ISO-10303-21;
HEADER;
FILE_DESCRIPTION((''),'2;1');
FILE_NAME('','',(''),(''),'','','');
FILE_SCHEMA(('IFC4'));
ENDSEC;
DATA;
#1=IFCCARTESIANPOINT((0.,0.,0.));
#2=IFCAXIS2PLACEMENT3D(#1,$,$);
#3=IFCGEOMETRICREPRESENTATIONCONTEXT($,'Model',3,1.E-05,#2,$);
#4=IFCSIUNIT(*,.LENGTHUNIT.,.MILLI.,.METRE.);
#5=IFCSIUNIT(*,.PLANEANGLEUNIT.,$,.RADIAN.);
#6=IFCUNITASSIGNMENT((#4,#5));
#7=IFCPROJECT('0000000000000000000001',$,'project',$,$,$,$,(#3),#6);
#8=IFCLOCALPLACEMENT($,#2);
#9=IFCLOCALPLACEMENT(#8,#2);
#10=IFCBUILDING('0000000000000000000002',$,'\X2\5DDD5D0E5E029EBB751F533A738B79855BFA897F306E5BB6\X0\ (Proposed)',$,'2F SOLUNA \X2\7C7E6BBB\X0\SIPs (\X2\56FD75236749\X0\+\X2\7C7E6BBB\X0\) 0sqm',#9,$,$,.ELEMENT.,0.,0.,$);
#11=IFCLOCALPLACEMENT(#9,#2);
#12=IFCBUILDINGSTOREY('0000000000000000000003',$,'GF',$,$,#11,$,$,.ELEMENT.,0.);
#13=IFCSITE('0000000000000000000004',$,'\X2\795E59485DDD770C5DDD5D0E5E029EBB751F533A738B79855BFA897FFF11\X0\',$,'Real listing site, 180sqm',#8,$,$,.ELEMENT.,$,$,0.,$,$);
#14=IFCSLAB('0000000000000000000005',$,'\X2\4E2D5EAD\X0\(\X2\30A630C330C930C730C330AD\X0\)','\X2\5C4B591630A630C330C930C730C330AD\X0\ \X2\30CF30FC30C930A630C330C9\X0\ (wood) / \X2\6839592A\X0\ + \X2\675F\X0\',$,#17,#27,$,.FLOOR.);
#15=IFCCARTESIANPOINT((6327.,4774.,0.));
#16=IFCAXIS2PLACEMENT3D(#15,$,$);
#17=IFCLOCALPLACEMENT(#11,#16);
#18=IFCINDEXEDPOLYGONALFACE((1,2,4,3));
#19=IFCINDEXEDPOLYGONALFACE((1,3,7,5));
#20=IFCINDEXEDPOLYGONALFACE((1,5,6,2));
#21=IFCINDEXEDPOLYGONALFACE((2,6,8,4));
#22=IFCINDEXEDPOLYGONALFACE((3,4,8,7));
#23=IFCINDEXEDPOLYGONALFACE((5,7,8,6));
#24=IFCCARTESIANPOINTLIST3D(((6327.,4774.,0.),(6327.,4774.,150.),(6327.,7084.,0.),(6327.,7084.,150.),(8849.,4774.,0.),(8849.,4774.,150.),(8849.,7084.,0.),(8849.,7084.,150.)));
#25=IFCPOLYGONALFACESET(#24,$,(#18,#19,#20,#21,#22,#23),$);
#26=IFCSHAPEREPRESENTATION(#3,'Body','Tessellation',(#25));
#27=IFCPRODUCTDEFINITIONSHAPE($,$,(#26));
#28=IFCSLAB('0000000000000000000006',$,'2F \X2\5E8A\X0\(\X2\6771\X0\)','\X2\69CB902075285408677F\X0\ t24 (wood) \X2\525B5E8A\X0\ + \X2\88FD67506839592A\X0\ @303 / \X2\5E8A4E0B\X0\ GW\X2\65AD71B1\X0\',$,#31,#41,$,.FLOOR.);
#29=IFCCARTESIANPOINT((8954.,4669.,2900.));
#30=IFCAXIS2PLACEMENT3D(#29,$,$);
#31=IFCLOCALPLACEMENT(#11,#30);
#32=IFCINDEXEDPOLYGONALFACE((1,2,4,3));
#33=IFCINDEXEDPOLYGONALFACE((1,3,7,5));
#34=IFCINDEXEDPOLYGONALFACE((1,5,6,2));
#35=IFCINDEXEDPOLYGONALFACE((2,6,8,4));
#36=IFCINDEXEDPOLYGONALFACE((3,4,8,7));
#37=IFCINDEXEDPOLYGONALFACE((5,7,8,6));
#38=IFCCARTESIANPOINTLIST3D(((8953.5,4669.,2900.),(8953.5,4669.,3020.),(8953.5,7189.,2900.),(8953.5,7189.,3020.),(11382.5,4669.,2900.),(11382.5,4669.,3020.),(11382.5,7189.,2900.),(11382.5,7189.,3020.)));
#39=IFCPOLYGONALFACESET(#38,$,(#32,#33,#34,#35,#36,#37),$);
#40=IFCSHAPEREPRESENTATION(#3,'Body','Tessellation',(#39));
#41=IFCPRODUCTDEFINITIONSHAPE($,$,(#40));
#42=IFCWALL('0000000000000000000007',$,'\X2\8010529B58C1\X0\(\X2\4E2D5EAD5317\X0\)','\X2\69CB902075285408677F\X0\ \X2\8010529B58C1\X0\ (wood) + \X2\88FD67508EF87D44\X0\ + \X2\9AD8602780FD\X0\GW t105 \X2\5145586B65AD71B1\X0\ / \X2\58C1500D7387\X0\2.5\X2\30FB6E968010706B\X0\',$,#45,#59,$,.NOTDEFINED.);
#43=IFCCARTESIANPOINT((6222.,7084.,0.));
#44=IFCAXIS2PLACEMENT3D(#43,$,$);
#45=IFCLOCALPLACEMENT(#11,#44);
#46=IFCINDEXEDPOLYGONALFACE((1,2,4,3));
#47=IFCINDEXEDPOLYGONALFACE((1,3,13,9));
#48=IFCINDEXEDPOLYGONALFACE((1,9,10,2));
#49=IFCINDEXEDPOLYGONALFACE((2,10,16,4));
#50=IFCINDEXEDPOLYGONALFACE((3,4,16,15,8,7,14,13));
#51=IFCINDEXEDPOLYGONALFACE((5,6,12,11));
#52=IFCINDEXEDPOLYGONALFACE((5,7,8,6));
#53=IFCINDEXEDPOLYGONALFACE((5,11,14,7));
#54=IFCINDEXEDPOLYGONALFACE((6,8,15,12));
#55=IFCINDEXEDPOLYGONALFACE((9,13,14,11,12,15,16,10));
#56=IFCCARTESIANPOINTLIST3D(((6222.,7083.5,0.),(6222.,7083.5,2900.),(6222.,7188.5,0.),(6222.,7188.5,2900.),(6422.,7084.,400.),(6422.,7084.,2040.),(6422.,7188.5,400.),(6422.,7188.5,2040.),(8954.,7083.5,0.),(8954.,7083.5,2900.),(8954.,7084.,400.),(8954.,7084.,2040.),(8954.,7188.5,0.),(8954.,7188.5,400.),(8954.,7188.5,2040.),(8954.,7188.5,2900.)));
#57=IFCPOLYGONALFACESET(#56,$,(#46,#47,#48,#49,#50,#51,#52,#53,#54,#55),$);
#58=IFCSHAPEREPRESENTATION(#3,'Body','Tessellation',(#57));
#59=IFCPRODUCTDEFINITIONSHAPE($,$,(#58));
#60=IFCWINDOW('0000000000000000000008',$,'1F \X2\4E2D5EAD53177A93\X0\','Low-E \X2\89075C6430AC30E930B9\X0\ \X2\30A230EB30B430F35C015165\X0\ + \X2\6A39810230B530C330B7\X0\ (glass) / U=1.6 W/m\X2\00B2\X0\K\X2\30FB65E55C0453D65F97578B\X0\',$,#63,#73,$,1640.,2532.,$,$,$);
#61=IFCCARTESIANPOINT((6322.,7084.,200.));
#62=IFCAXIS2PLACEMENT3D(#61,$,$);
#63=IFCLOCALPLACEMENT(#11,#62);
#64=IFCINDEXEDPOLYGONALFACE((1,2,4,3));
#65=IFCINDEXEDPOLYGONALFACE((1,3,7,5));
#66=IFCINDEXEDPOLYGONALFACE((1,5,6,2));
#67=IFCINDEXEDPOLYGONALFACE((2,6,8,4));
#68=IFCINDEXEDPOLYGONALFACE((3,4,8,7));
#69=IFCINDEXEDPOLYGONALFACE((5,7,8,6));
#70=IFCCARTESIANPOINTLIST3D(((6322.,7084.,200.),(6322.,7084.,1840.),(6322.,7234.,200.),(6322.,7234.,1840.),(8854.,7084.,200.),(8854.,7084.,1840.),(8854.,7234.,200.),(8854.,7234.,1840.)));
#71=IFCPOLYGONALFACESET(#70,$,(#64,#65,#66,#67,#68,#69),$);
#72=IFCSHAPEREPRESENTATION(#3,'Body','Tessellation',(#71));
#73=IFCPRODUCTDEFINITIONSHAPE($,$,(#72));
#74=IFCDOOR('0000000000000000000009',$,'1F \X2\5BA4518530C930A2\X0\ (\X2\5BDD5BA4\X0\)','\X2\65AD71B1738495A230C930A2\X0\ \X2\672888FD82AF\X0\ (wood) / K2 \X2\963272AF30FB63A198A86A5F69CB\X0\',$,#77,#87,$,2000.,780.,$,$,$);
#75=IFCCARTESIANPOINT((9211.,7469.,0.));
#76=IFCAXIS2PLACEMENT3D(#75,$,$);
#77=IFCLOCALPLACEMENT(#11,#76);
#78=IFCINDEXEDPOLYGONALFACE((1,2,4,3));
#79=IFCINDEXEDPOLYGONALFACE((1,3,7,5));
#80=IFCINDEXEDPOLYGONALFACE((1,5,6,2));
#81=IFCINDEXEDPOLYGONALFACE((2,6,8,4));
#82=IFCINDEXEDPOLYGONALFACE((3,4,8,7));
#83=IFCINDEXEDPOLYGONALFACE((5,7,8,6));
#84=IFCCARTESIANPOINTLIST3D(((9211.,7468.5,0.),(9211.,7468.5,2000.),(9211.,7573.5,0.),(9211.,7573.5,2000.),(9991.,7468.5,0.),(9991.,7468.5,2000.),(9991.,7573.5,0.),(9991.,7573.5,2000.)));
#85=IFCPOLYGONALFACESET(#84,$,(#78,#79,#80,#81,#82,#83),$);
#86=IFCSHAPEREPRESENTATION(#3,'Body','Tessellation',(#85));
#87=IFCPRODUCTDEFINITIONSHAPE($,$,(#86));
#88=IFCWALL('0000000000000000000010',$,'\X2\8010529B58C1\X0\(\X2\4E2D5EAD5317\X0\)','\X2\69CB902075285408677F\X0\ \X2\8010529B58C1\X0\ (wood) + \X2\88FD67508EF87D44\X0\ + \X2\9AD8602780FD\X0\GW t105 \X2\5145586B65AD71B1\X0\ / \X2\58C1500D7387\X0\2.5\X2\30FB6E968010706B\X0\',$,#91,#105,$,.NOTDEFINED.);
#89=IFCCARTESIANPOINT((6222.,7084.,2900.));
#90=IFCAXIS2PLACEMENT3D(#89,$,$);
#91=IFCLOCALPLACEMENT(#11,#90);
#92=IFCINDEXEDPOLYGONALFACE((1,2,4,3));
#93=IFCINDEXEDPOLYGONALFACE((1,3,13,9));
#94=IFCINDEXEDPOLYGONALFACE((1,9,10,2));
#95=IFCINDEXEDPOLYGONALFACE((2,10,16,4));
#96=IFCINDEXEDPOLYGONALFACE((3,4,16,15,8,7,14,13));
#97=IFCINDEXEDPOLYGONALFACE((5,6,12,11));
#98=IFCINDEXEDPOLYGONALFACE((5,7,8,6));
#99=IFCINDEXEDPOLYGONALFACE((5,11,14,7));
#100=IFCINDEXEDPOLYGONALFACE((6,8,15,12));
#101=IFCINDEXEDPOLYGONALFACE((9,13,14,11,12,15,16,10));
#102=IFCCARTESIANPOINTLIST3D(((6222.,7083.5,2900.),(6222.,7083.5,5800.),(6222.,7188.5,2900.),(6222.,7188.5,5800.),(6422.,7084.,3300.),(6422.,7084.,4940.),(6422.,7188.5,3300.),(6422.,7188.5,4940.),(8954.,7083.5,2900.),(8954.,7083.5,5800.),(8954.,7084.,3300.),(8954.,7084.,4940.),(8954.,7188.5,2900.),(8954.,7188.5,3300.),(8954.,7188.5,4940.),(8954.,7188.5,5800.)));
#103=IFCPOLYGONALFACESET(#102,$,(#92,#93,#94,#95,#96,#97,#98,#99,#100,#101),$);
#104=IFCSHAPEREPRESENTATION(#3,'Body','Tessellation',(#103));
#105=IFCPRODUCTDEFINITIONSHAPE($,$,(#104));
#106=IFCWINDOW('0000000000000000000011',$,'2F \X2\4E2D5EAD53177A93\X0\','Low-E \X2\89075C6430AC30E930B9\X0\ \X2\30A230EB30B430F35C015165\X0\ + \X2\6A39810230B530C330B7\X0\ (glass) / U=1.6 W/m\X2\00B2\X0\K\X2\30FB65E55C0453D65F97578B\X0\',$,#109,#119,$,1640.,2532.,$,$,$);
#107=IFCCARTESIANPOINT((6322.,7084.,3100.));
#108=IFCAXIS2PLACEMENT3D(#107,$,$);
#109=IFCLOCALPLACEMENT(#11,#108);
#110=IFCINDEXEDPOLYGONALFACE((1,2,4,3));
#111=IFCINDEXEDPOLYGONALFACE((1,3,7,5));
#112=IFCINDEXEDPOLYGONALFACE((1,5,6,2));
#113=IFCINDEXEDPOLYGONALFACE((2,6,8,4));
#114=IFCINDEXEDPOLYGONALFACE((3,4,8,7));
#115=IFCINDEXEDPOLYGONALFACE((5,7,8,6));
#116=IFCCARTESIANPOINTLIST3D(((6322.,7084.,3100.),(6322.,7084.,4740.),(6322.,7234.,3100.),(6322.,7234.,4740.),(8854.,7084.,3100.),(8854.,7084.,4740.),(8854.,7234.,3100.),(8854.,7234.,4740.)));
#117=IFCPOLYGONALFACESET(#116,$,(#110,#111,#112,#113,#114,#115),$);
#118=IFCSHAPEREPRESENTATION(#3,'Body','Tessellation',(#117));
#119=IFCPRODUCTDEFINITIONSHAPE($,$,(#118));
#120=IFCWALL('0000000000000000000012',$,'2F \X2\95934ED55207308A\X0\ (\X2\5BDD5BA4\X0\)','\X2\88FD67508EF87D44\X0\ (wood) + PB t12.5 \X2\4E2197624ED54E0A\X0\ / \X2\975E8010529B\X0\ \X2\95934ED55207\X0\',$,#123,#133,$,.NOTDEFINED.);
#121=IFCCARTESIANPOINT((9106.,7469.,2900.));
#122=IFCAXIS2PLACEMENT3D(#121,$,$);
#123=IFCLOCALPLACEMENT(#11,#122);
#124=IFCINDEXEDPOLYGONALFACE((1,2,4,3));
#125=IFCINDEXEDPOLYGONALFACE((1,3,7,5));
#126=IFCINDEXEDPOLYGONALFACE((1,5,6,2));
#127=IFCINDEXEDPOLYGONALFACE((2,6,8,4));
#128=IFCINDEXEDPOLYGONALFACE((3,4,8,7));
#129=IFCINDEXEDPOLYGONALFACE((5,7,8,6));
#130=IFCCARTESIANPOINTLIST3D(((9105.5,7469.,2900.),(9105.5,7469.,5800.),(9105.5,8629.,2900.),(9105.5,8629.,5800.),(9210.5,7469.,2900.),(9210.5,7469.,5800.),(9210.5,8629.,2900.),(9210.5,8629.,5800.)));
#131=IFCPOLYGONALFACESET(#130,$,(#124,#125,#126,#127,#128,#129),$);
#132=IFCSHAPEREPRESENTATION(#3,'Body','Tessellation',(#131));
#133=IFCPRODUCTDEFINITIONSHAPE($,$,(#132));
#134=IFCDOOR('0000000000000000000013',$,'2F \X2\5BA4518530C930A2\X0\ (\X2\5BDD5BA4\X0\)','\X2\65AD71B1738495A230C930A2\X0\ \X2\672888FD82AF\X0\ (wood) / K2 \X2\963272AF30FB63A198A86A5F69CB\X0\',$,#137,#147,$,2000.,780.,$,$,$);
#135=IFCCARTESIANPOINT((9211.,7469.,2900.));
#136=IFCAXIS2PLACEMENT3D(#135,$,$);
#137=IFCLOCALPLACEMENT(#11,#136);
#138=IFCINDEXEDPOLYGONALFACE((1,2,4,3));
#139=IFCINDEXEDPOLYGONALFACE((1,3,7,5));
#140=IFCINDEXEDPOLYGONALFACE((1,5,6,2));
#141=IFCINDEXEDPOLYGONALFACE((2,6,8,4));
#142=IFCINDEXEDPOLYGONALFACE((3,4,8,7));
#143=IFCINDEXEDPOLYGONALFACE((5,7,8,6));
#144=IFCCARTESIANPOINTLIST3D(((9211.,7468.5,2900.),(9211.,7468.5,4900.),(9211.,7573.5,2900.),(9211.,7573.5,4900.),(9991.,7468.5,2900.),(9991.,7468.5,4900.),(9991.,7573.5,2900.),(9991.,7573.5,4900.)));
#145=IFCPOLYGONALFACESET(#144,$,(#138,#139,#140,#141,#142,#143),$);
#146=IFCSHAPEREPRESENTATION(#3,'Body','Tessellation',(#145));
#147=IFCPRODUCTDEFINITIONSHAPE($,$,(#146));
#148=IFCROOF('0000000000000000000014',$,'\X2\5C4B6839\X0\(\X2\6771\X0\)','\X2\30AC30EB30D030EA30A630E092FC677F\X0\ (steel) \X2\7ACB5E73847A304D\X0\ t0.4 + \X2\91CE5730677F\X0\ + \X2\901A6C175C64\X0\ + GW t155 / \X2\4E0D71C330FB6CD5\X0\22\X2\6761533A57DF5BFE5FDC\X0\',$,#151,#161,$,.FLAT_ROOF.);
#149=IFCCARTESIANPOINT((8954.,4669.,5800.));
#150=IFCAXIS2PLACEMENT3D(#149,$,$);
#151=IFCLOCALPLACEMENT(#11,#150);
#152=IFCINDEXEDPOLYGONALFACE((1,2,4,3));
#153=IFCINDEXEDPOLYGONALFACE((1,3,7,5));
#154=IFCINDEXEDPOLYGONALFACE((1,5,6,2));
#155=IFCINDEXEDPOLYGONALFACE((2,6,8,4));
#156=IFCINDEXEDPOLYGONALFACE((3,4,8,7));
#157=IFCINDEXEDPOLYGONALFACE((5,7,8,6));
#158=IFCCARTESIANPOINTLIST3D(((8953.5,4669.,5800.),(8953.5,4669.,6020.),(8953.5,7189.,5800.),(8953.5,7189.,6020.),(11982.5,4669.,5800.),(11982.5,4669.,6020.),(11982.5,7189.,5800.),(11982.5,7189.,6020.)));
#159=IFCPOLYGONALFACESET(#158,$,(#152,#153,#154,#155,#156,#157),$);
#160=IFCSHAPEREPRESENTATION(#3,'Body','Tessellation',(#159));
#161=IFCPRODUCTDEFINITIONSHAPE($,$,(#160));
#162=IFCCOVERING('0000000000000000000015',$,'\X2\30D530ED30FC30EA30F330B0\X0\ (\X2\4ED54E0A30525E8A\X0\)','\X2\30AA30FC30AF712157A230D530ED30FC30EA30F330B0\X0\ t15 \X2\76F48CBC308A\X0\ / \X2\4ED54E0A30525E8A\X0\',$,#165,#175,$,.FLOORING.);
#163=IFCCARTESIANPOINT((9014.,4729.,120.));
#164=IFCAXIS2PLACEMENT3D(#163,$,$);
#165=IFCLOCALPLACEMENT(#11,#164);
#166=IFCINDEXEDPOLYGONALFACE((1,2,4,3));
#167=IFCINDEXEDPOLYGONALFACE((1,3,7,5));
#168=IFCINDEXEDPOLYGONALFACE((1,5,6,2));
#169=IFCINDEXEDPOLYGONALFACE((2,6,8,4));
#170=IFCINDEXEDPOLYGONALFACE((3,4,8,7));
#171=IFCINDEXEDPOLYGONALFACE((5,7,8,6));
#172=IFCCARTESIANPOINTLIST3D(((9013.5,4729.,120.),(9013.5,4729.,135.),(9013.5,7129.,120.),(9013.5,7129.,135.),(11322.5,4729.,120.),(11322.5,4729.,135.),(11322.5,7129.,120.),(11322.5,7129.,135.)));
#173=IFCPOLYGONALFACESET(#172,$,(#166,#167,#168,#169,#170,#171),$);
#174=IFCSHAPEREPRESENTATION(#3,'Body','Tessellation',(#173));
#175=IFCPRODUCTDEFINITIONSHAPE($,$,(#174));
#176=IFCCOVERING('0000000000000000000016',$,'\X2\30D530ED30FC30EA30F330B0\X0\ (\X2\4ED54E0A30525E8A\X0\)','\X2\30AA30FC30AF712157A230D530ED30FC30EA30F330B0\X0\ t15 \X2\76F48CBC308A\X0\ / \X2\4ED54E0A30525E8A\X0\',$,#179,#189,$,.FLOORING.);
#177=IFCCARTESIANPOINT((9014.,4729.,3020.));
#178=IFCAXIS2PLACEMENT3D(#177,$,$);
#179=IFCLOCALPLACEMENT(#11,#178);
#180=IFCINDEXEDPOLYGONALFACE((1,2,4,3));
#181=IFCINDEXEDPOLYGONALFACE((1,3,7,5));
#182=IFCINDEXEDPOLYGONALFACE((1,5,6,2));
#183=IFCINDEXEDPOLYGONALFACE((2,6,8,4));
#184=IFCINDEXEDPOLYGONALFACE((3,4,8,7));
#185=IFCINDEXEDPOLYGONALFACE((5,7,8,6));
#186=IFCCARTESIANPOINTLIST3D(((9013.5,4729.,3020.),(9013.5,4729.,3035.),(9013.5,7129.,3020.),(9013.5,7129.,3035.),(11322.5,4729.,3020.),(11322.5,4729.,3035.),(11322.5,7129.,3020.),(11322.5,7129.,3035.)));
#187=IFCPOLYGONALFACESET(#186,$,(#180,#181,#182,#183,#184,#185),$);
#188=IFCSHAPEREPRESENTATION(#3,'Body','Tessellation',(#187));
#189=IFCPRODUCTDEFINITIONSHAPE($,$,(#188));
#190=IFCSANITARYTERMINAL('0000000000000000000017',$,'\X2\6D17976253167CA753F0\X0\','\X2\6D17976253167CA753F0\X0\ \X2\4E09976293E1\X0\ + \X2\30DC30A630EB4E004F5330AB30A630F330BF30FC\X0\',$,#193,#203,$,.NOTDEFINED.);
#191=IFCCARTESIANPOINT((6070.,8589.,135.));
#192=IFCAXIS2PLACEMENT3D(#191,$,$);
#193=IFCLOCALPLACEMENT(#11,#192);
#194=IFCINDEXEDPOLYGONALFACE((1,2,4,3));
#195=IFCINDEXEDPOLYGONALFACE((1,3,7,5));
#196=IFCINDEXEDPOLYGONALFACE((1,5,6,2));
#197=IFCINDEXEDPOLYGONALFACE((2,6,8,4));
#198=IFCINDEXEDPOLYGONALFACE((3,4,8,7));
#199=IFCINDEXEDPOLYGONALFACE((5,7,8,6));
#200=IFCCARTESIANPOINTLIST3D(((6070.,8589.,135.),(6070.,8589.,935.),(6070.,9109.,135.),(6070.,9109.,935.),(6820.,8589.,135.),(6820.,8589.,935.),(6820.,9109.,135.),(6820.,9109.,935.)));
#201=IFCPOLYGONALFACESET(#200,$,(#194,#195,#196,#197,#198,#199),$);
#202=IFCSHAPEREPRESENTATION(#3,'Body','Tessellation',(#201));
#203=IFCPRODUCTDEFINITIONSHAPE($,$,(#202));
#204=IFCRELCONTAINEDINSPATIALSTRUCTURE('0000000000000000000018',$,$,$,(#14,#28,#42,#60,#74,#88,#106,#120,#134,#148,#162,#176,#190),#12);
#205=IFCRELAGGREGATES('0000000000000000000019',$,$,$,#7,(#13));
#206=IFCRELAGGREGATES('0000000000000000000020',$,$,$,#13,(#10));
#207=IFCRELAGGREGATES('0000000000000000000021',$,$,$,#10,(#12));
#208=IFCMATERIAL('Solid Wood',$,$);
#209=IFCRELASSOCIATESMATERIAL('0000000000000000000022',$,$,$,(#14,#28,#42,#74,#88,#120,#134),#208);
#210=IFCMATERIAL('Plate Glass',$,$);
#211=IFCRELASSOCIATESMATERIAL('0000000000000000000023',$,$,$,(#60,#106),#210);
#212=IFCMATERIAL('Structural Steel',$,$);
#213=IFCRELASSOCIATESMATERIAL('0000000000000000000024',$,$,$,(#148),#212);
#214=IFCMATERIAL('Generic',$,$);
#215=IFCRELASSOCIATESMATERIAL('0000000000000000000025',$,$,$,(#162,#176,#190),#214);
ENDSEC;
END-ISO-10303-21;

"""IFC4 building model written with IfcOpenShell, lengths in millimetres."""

from ifc_helpers import new_model, si_unit, frame, frame_2d, origin, place, context, project, spatial, rectangle, extrude, material, element, fill, save


model = new_model("IFC4")

# Units and contexts
model_context = context("Model", 3, precision=1e-05, world=origin())
ifc_project = project(units=[si_unit("LENGTHUNIT", "METRE", prefix="MILLI"), si_unit("PLANEANGLEUNIT", "RADIAN")], contexts=[model_context])

# Site, building, storey
site_placement = place(None, origin())
site = spatial("IfcSite", under=ifc_project, at=site_placement, Name="神奈川県川崎市麻生区王禅寺西１", ObjectType="Real listing site, 180sqm", CompositionType="ELEMENT", RefElevation=0.0)
building_placement = place(site_placement, origin())
building = spatial("IfcBuilding", under=site, at=building_placement, Name="川崎市麻生区王禅寺西の家 (Proposed)", ObjectType="2F SOLUNA 籾殻SIPs (国産杉+籾殻) 0sqm", CompositionType="ELEMENT", ElevationOfRefHeight=0.0, ElevationOfTerrain=0.0)
storey_placement = place(building_placement, origin())
storey = spatial("IfcBuildingStorey", under=building, at=storey_placement, Name="GF", CompositionType="ELEMENT", Elevation=0.0)

# Slabs
ifc_material_1 = material(Name="Solid Wood")
slab_1_placement = place(storey_placement, frame((6327.0, 4774.0, 0.0)))
element("IfcSlab", 1, at=slab_1_placement, inside=storey, material=ifc_material_1, Name="中庭(ウッドデッキ)", Description="屋外ウッドデッキ ハードウッド (wood) / 根太 + 束", PredefinedType="FLOOR", context=model_context, shape_type="SweptSolid", body=[
    extrude(rectangle(XDim=2522.0, YDim=2310.0, at=frame_2d((1261.0, 1155.0))), frame((6327.0, 4774.0, 0.0)), (0.0, 0.0, 1.0), 150.0),
])
slab_2_placement = place(storey_placement, frame((8954.0, 4669.0, 2900.0)))
element("IfcSlab", 2, at=slab_2_placement, inside=storey, material=ifc_material_1, Name="2F 床(東)", Description="構造用合板 t24 (wood) 剛床 + 製材根太 @303 / 床下 GW断熱", PredefinedType="FLOOR", context=model_context, shape_type="SweptSolid", body=[
    extrude(rectangle(XDim=2429.0, YDim=2520.0, at=frame_2d((1214.0, 1260.0))), frame((8954.0, 4669.0, 2900.0)), (0.0, 0.0, 1.0), 120.0),
])

# Wall, opening, window
wall_1_placement = place(storey_placement, frame((6222.0, 7084.0, 0.0)))
wall_1 = element("IfcWall", 3, at=wall_1_placement, inside=storey, material=ifc_material_1, Name="耐力壁(中庭北)", Description="構造用合板 耐力壁 (wood) + 製材軸組 + 高性能GW t105 充填断熱 / 壁倍率2.5・準耐火", PredefinedType="NOTDEFINED", context=model_context, shape_type="SweptSolid", body=[
    extrude(rectangle(XDim=2732.0, YDim=105.0, at=frame_2d((1366.0, 52.0))), frame((6222.0, 7084.0, 0.0)), (0.0, 0.0, 1.0), 2900.0),
])
opening_1_placement = place(storey_placement, frame((6322.0, 7084.0, 200.0)))
opening_1 = element("IfcOpeningElement", 4, at=opening_1_placement, cuts=wall_1, PredefinedType="NOTDEFINED", context=model_context, shape_type="SweptSolid", body=[
    extrude(rectangle(XDim=2532.0, YDim=150.0, at=frame_2d((1266.0, 75.0))), frame((6322.0, 7084.0, 200.0)), (0.0, 0.0, 1.0), 1640.0),
])
ifc_material_2 = material(Name="Plate Glass")
window_1_placement = place(storey_placement, frame((6322.0, 7084.0, 200.0)))
window_1 = element("IfcWindow", 5, at=window_1_placement, inside=storey, material=ifc_material_2, Name="1F 中庭北窓", Description="Low-E 複層ガラス アルゴン封入 + 樹脂サッシ (glass) / U=1.6 W/m²K・日射取得型", OverallHeight=1640.0, OverallWidth=2532.0, context=model_context, shape_type="SweptSolid", body=[
    extrude(rectangle(XDim=2532.0, YDim=150.0, at=frame_2d((1266.0, 75.0))), frame((6322.0, 7084.0, 200.0)), (0.0, 0.0, 1.0), 1640.0),
])
fill(opening_1, window_1)

# Door
door_1_placement = place(storey_placement, frame((9211.0, 7469.0, 0.0)))
element("IfcDoor", 6, at=door_1_placement, inside=storey, material=ifc_material_1, Name="1F 室内ドア (寝室)", Description="断熱玄関ドア 木製芯 (wood) / K2 防犯・採風機構", OverallHeight=2000.0, OverallWidth=780.0, context=model_context, shape_type="SweptSolid", body=[
    extrude(rectangle(XDim=780.0, YDim=105.0, at=frame_2d((390.0, 52.0))), frame((9211.0, 7469.0, 0.0)), (0.0, 0.0, 1.0), 2000.0),
])

# Wall, opening, window
wall_2_placement = place(storey_placement, frame((6222.0, 7084.0, 2900.0)))
wall_2 = element("IfcWall", 7, at=wall_2_placement, inside=storey, material=ifc_material_1, Name="耐力壁(中庭北)", Description="構造用合板 耐力壁 (wood) + 製材軸組 + 高性能GW t105 充填断熱 / 壁倍率2.5・準耐火", PredefinedType="NOTDEFINED", context=model_context, shape_type="SweptSolid", body=[
    extrude(rectangle(XDim=2732.0, YDim=105.0, at=frame_2d((1366.0, 52.0))), frame((6222.0, 7084.0, 2900.0)), (0.0, 0.0, 1.0), 2900.0),
])
opening_2_placement = place(storey_placement, frame((6322.0, 7084.0, 3100.0)))
opening_2 = element("IfcOpeningElement", 8, at=opening_2_placement, cuts=wall_2, PredefinedType="NOTDEFINED", context=model_context, shape_type="SweptSolid", body=[
    extrude(rectangle(XDim=2532.0, YDim=150.0, at=frame_2d((1266.0, 75.0))), frame((6322.0, 7084.0, 3100.0)), (0.0, 0.0, 1.0), 1640.0),
])
window_2_placement = place(storey_placement, frame((6322.0, 7084.0, 3100.0)))
window_2 = element("IfcWindow", 9, at=window_2_placement, inside=storey, material=ifc_material_2, Name="2F 中庭北窓", Description="Low-E 複層ガラス アルゴン封入 + 樹脂サッシ (glass) / U=1.6 W/m²K・日射取得型", OverallHeight=1640.0, OverallWidth=2532.0, context=model_context, shape_type="SweptSolid", body=[
    extrude(rectangle(XDim=2532.0, YDim=150.0, at=frame_2d((1266.0, 75.0))), frame((6322.0, 7084.0, 3100.0)), (0.0, 0.0, 1.0), 1640.0),
])
fill(opening_2, window_2)

# Wall
wall_3_placement = place(storey_placement, frame((9106.0, 7469.0, 2900.0)))
element("IfcWall", 10, at=wall_3_placement, inside=storey, material=ifc_material_1, Name="2F 間仕切り (寝室)", Description="製材軸組 (wood) + PB t12.5 両面仕上 / 非耐力 間仕切", PredefinedType="NOTDEFINED", context=model_context, shape_type="SweptSolid", body=[
    extrude(rectangle(XDim=105.0, YDim=1160.0, at=frame_2d((52.0, 580.0))), frame((9106.0, 7469.0, 2900.0)), (0.0, 0.0, 1.0), 2900.0),
])

# Door
door_2_placement = place(storey_placement, frame((9211.0, 7469.0, 2900.0)))
element("IfcDoor", 11, at=door_2_placement, inside=storey, material=ifc_material_1, Name="2F 室内ドア (寝室)", Description="断熱玄関ドア 木製芯 (wood) / K2 防犯・採風機構", OverallHeight=2000.0, OverallWidth=780.0, context=model_context, shape_type="SweptSolid", body=[
    extrude(rectangle(XDim=780.0, YDim=105.0, at=frame_2d((390.0, 52.0))), frame((9211.0, 7469.0, 2900.0)), (0.0, 0.0, 1.0), 2000.0),
])

# Roof
ifc_material_3 = material(Name="Structural Steel")
for number, where, name in (
    (12, (8954.0, 4669.0, 5800.0), "屋根(東)"),
):
    element("IfcRoof", number, at=place(storey_placement, frame(where)), inside=storey, material=ifc_material_3, Name=name, Description="ガルバリウム鋼板 (steel) 立平葺き t0.4 + 野地板 + 通気層 + GW t155 / 不燃・法22条区域対応", PredefinedType="FLAT_ROOF", context=model_context, shape_type="SweptSolid", body=[
        extrude(rectangle(XDim=3029.0, YDim=2520.0, at=frame_2d((1514.0, 1260.0))), frame((8954.0, 4669.0, 5800.0)), (0.0, 0.0, 1.0), 220.0),
    ])

# Coverings
ifc_material_4 = material(Name="Generic")
covering_1_placement = place(storey_placement, frame((9014.0, 4729.0, 120.0)))
element("IfcCovering", 13, at=covering_1_placement, inside=storey, material=ifc_material_4, Name="フローリング (仕上げ床)", Description="オーク無垢フローリング t15 直貼り / 仕上げ床", PredefinedType="FLOORING", context=model_context, shape_type="SweptSolid", body=[
    extrude(rectangle(XDim=2309.0, YDim=2400.0, at=frame_2d((1154.0, 1200.0))), frame((9014.0, 4729.0, 120.0)), (0.0, 0.0, 1.0), 15.0),
])
covering_2_placement = place(storey_placement, frame((9014.0, 4729.0, 3020.0)))
element("IfcCovering", 14, at=covering_2_placement, inside=storey, material=ifc_material_4, Name="フローリング (仕上げ床)", Description="オーク無垢フローリング t15 直貼り / 仕上げ床", PredefinedType="FLOORING", context=model_context, shape_type="SweptSolid", body=[
    extrude(rectangle(XDim=2309.0, YDim=2400.0, at=frame_2d((1154.0, 1200.0))), frame((9014.0, 4729.0, 3020.0)), (0.0, 0.0, 1.0), 15.0),
])

# Sanitary terminal
sanitary_terminal_1_placement = place(storey_placement, frame((6070.0, 8589.0, 135.0)))
element("IfcSanitaryTerminal", 15, at=sanitary_terminal_1_placement, inside=storey, material=ifc_material_4, Name="洗面化粧台", Description="洗面化粧台 三面鏡 + ボウル一体カウンター", PredefinedType="NOTDEFINED", context=model_context, shape_type="SweptSolid", body=[
    extrude(rectangle(XDim=750.0, YDim=520.0, at=frame_2d((375.0, 260.0))), frame((6070.0, 8589.0, 135.0)), (0.0, 0.0, 1.0), 800.0),
])

save(model, "model.ifc")
